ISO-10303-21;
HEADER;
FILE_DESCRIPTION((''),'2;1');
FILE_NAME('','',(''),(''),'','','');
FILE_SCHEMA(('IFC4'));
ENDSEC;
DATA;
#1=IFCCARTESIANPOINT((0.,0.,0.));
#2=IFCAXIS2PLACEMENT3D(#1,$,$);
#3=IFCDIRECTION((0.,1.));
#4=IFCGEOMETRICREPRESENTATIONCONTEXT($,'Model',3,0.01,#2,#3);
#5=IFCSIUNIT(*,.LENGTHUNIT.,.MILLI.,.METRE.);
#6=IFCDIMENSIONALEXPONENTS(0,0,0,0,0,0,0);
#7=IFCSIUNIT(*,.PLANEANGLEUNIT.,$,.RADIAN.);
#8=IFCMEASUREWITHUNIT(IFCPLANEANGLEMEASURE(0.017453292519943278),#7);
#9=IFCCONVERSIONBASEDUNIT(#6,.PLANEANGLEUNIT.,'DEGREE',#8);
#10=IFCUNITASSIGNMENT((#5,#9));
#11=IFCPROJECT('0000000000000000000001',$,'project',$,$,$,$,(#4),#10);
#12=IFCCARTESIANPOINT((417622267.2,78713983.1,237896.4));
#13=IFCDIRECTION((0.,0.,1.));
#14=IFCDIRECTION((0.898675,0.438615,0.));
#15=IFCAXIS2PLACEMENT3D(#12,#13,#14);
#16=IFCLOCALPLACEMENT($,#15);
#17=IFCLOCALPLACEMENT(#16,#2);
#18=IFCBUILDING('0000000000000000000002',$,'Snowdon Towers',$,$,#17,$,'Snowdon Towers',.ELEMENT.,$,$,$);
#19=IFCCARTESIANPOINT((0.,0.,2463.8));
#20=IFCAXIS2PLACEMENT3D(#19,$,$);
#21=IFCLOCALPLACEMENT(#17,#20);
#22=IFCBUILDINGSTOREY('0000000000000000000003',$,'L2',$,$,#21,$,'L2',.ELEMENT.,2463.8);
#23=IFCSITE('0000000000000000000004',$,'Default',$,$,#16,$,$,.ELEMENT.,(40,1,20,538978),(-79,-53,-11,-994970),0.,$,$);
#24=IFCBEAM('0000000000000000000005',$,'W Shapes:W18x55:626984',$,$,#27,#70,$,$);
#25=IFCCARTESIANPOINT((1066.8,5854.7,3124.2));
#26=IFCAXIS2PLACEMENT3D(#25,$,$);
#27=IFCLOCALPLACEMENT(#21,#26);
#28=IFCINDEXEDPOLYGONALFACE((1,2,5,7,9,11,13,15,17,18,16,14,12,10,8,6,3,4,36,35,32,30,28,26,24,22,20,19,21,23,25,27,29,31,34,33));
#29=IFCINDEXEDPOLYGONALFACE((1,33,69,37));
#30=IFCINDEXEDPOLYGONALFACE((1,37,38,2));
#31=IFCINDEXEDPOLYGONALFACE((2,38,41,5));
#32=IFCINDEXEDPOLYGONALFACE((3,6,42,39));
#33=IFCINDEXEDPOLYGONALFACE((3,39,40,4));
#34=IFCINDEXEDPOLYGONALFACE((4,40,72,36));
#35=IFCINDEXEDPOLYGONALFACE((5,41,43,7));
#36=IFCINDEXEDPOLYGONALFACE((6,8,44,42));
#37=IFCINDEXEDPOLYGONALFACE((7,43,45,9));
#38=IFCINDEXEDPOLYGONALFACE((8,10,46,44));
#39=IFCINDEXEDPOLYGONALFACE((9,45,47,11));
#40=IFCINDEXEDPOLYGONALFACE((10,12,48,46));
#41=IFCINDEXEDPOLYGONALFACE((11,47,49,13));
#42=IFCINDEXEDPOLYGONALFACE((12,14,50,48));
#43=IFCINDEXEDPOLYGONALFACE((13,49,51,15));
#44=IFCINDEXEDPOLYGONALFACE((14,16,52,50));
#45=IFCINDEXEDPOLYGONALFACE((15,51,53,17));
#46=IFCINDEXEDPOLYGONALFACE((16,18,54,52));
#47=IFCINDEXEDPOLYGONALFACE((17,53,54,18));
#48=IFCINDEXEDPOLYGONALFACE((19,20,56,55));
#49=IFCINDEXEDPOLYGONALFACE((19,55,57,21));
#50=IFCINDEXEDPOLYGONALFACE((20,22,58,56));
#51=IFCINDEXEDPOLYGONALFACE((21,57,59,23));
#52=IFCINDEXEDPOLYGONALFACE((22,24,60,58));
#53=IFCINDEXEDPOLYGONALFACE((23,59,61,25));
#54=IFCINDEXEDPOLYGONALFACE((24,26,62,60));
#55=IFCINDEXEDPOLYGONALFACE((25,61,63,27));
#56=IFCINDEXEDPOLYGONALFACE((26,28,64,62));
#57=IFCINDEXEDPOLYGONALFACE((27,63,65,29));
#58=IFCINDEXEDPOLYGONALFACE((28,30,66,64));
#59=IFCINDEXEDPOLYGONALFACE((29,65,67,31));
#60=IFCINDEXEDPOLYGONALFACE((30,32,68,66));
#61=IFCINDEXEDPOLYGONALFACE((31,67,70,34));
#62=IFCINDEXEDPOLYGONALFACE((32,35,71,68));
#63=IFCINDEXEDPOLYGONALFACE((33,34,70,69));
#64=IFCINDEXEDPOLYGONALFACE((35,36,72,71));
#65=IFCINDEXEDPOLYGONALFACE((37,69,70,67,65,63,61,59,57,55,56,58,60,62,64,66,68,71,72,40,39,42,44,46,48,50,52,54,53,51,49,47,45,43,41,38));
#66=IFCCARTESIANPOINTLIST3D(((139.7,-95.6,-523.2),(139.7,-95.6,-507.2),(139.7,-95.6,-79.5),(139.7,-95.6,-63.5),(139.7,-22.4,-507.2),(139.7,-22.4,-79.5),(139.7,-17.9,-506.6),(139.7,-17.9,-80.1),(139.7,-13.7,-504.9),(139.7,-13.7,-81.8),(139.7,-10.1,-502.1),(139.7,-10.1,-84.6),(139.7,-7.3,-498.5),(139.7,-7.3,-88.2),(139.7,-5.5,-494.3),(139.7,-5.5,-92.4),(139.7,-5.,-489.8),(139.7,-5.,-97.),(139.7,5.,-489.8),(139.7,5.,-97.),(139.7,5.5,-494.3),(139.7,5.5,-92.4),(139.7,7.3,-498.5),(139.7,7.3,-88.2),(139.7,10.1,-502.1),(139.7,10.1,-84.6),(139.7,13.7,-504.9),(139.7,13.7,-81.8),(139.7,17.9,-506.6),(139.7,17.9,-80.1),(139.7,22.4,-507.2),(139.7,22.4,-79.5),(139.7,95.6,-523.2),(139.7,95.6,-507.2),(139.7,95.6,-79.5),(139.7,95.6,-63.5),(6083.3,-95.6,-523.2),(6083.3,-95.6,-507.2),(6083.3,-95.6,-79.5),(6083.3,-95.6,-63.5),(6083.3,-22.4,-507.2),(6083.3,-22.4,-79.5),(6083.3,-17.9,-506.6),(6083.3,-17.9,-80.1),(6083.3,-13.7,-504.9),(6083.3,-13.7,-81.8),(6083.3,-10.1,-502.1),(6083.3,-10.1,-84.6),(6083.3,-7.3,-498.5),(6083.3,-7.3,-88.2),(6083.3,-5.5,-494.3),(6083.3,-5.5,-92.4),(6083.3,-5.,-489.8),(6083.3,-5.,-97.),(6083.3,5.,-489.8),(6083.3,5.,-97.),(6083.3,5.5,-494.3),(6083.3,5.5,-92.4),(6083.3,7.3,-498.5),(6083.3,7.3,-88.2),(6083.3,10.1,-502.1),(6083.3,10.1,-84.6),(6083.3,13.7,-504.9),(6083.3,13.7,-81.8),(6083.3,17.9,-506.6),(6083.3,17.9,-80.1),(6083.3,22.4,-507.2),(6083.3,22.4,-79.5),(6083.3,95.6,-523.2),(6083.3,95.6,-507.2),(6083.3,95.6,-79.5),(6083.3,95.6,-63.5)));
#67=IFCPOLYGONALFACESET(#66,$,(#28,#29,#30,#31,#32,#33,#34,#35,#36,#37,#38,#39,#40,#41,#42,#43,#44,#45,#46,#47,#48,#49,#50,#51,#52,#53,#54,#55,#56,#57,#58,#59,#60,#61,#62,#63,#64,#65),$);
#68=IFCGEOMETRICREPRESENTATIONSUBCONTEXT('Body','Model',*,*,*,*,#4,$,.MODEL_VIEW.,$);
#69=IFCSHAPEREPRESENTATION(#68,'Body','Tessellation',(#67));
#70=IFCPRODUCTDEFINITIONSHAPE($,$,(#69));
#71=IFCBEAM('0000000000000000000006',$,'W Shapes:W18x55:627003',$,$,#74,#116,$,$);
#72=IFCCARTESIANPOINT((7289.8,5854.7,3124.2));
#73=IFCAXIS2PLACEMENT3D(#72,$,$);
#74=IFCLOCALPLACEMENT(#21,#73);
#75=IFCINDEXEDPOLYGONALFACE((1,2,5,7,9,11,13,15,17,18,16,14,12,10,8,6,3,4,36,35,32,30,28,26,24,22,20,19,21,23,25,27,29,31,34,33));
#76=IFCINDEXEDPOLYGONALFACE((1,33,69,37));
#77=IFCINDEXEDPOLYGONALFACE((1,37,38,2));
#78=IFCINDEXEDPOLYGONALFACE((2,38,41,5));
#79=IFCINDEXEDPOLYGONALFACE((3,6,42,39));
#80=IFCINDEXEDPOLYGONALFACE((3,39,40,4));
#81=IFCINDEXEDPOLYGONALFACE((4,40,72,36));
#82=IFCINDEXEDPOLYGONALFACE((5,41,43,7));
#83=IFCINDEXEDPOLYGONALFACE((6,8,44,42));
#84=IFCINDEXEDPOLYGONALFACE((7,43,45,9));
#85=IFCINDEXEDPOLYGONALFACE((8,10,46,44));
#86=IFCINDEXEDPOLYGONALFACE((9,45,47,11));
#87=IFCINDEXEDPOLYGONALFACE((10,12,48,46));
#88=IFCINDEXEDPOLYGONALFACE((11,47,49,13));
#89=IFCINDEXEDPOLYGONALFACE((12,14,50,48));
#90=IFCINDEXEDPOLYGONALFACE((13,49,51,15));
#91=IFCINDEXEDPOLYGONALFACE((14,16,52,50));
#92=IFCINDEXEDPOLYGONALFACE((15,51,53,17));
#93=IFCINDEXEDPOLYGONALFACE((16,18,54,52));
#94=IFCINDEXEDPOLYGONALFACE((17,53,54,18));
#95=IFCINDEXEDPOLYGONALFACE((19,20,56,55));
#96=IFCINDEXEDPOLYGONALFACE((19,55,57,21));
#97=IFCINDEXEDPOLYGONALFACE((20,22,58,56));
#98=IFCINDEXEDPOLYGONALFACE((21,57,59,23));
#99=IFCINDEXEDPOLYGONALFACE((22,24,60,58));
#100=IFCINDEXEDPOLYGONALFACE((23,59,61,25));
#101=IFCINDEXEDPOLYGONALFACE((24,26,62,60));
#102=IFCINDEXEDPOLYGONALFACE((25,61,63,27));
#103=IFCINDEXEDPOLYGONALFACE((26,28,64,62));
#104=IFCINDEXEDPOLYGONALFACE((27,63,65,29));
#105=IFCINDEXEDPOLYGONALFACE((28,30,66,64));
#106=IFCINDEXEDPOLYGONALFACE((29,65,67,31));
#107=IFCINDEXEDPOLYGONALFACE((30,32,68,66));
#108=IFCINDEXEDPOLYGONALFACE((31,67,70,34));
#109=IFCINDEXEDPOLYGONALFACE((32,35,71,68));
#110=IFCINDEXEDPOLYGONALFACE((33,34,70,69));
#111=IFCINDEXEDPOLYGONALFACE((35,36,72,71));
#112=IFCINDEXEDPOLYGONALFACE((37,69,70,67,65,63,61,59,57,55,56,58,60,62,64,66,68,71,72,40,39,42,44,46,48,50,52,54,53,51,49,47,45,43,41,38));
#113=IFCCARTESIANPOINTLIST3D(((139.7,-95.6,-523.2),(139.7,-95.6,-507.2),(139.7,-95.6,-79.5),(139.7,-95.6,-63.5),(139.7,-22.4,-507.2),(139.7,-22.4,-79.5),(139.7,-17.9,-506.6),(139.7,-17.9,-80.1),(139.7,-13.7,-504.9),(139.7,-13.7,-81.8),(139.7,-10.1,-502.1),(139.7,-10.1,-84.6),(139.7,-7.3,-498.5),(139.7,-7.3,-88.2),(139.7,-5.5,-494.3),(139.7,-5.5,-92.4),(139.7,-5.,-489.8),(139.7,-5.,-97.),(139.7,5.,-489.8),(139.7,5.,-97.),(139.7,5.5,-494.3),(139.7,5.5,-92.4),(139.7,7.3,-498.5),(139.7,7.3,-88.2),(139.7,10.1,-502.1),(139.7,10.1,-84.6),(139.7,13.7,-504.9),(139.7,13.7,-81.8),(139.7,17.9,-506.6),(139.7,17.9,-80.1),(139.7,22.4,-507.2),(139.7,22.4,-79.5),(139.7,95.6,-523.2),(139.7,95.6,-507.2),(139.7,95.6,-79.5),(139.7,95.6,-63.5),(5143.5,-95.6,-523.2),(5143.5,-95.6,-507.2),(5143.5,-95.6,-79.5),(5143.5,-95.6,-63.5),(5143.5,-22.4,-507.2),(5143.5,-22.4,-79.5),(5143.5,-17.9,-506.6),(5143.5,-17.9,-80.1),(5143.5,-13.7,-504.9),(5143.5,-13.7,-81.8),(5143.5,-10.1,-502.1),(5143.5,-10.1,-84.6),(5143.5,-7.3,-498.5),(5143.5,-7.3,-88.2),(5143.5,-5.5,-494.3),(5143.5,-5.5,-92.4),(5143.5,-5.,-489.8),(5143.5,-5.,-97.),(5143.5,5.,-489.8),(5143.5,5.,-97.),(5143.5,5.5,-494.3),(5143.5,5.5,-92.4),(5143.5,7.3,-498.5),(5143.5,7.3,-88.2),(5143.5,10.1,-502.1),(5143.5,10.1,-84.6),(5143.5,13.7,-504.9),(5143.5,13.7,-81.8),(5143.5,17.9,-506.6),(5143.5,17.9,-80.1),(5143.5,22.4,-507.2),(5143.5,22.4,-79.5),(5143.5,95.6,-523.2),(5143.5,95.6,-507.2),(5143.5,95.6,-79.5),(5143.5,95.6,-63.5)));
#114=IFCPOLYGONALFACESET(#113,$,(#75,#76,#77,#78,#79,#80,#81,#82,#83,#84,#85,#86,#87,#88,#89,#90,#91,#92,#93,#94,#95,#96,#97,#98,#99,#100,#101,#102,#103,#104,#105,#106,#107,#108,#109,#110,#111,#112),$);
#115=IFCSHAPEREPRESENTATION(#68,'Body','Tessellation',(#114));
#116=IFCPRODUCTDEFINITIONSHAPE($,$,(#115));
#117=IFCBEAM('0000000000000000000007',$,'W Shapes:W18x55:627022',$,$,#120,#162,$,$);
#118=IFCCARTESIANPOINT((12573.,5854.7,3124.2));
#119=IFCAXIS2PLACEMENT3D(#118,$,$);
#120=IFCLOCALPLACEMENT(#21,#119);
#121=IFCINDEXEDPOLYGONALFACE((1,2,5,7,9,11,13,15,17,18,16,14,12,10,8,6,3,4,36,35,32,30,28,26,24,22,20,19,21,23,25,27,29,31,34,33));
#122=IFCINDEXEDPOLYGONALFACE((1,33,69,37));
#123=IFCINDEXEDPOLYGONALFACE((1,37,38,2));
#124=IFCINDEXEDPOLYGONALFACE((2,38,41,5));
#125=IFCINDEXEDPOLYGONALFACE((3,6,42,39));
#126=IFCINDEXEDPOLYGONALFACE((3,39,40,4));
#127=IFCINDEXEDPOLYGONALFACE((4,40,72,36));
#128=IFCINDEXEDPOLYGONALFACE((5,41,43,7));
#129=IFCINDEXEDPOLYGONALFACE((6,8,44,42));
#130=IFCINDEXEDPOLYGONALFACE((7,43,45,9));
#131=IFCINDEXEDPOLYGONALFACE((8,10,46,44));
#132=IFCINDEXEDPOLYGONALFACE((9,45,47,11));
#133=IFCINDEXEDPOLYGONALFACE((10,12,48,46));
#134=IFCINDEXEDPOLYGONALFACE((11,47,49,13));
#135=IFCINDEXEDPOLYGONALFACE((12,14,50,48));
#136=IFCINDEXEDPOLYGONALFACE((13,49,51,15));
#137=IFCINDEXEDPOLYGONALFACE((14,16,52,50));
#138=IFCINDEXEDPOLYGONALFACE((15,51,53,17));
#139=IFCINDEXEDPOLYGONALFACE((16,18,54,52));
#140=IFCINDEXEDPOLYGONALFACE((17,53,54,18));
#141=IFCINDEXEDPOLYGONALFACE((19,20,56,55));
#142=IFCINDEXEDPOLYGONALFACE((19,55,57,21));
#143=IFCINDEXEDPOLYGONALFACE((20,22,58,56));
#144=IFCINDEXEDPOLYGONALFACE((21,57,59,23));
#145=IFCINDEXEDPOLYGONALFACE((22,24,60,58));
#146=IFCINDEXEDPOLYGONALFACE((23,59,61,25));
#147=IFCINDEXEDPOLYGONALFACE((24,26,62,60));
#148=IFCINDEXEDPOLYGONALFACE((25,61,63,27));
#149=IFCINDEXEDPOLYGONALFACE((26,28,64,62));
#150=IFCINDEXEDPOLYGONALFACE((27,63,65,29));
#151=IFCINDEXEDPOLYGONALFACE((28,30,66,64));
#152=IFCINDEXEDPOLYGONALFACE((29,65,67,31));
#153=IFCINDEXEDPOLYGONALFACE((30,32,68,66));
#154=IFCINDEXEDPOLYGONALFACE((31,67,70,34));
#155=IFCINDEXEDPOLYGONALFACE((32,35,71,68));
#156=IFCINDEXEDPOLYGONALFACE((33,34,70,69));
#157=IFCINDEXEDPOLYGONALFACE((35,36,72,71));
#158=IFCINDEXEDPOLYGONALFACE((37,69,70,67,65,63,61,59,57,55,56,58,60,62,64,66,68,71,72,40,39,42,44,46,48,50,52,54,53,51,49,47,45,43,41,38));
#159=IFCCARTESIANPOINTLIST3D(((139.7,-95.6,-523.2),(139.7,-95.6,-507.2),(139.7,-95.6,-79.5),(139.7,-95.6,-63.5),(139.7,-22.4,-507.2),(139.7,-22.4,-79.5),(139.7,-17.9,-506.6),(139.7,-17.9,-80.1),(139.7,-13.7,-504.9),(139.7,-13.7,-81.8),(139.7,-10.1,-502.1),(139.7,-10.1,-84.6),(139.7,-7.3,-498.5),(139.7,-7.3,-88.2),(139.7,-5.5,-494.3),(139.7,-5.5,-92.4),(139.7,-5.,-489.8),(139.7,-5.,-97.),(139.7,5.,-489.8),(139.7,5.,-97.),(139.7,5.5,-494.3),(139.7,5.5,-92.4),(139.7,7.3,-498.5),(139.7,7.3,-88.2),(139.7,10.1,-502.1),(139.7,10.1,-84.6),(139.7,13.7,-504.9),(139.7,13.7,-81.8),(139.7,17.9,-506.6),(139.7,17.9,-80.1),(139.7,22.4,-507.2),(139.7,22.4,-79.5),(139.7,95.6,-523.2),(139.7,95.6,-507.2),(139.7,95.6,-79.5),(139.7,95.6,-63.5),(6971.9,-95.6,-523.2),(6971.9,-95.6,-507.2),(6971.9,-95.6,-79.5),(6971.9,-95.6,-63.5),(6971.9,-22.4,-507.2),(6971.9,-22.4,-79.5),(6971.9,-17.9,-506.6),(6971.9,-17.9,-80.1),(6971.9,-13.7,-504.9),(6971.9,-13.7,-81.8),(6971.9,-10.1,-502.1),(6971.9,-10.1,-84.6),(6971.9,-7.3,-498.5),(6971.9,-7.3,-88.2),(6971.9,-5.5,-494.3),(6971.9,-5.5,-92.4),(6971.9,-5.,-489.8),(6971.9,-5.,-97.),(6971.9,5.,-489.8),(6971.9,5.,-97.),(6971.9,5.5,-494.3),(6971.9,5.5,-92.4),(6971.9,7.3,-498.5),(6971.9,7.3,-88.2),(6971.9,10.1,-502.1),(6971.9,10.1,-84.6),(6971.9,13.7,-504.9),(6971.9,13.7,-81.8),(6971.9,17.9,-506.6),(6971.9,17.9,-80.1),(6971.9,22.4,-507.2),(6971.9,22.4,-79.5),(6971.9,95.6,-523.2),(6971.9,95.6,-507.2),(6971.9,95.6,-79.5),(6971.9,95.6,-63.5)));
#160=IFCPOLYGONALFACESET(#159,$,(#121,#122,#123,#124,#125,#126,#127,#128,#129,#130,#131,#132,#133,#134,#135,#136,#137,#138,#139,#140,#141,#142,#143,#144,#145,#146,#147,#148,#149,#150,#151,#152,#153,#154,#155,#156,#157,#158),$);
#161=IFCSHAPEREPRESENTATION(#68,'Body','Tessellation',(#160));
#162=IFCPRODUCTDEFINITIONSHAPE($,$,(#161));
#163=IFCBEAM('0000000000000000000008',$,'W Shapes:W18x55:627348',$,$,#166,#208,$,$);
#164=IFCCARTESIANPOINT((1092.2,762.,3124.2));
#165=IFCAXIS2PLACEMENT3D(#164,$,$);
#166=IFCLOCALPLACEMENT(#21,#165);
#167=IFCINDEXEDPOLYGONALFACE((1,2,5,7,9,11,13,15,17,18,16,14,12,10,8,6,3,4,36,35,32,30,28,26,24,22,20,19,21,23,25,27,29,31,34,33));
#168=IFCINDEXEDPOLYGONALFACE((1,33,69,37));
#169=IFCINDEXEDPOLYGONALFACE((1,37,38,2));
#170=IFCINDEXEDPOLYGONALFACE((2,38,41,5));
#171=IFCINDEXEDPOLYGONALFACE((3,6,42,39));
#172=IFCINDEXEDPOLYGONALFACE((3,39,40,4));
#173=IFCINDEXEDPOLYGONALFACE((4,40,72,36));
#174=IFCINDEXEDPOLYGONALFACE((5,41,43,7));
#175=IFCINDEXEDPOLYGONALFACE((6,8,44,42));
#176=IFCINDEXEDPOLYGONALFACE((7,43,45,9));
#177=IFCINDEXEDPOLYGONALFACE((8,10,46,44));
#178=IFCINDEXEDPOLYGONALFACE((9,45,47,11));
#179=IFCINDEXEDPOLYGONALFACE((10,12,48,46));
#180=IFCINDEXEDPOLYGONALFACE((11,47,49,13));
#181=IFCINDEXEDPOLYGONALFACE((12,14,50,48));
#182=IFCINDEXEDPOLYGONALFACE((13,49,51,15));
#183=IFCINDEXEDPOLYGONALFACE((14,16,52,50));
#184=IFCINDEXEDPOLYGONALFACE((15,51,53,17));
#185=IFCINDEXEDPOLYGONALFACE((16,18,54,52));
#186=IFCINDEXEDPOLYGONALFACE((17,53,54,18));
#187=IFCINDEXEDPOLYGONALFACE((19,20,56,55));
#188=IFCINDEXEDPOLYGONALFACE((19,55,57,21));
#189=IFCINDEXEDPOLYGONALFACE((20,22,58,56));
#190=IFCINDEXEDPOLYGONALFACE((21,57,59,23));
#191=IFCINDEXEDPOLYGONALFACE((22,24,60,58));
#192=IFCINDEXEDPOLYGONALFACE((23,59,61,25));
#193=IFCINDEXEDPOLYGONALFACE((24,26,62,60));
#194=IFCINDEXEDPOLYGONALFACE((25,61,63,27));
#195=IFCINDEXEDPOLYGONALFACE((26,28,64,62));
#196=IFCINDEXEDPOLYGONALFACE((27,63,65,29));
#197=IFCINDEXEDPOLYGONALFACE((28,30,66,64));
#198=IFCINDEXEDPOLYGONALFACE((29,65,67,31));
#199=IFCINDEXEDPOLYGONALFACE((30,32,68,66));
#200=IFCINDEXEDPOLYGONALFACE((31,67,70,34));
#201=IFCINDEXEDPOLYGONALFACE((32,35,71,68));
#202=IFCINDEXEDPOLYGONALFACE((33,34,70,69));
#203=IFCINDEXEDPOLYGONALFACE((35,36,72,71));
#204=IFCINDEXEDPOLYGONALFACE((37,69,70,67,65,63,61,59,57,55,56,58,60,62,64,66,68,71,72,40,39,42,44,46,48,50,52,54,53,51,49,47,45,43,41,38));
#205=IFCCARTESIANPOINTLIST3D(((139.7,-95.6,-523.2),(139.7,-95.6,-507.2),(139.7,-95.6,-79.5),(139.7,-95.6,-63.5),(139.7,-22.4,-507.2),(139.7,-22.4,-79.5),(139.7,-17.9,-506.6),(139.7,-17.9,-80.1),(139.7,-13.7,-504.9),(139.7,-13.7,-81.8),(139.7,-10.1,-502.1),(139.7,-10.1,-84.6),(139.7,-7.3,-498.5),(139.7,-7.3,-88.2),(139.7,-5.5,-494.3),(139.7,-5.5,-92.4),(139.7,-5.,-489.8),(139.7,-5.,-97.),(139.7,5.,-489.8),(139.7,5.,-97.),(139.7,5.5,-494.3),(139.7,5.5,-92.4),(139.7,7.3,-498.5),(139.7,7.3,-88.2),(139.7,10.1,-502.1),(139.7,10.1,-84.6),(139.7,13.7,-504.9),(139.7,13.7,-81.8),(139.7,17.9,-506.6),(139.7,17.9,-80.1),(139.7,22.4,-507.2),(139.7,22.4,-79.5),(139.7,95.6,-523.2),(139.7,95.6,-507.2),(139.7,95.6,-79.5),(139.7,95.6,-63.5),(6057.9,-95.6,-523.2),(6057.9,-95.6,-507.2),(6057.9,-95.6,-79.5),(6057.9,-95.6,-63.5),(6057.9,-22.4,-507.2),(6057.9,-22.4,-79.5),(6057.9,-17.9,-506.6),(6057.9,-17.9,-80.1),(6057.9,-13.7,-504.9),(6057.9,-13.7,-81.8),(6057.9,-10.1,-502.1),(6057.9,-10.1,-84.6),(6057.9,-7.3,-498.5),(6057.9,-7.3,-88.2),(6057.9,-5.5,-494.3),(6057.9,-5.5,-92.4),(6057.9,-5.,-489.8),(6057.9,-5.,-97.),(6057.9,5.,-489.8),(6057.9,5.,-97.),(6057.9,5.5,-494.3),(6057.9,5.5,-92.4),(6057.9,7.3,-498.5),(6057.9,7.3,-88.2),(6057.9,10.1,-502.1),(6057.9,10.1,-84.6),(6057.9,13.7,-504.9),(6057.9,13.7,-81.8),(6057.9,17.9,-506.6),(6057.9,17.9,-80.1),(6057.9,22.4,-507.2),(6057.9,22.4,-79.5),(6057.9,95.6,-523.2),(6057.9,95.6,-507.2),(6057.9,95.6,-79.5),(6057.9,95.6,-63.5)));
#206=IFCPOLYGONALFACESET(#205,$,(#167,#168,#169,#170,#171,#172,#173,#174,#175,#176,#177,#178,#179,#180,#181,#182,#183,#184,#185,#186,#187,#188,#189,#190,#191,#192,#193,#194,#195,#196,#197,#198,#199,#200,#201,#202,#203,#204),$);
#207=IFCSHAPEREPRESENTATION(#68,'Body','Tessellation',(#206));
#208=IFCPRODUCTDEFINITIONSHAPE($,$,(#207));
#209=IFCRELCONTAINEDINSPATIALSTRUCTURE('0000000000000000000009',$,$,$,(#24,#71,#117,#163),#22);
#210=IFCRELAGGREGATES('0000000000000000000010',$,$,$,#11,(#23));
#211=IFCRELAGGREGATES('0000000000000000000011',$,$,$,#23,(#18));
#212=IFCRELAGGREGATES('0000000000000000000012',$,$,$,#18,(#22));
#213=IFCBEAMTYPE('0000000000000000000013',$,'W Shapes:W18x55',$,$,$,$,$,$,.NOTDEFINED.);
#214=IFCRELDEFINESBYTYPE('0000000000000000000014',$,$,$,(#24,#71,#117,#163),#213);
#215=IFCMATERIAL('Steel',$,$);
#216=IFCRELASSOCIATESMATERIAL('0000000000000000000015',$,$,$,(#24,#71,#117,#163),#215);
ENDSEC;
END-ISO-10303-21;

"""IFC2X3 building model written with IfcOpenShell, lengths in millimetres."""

from ifc_helpers import new_model, entity, si_unit, converted_unit, direction, frame, frame_2d, origin, place, context, subcontext, project, spatial, i_section, extrude, material, type_object, element, save


model = new_model("IFC2X3")

# Units and contexts
model_context = context("Model", 3, precision=0.01, world=origin(), true_north=direction((0.0, 1.0)))
body_context = subcontext(model_context, "Body", "Model", "MODEL_VIEW")
ifc_project = project(units=[si_unit("LENGTHUNIT", "METRE", prefix="MILLI"), converted_unit("PLANEANGLEUNIT", "DEGREE", entity("IfcPlaneAngleMeasure", 0.017453292519943278), si_unit("PLANEANGLEUNIT", "RADIAN"), dimensions=[0, 0, 0, 0, 0, 0, 0])], contexts=[model_context])

# Site, building, storey
site_placement = place(None, frame((417622267.2, 78713983.1, 237896.4), z_axis=(0.0, 0.0, 1.0), x_axis=(0.898675, 0.438615, 0.0)))
site = spatial("IfcSite", under=ifc_project, at=site_placement, Name="Default", CompositionType="ELEMENT", RefLatitude=(40, 1, 20, 538978), RefLongitude=(-79, -53, -11, -994970), RefElevation=0.0)
building_placement = place(site_placement, origin())
building = spatial("IfcBuilding", under=site, at=building_placement, Name="Snowdon Towers", LongName="Snowdon Towers", CompositionType="ELEMENT")
storey_placement = place(building_placement, frame((0.0, 0.0, 2463.8)))
storey = spatial("IfcBuildingStorey", under=building, at=storey_placement, Name="L2", LongName="L2", CompositionType="ELEMENT", Elevation=2463.8)

# Shared definitions
ifc_material_1 = material(Name="Steel")

# Beams
beam_type_1 = type_object("IfcBeamType", Name="W Shapes:W18x55", PredefinedType="NOTDEFINED")
beam_1_placement = place(storey_placement, frame((1066.8, 5854.7, 3124.2)))
element("IfcBeam", 1, at=beam_1_placement, inside=storey, type_object=beam_type_1, material=ifc_material_1, Name="W Shapes:W18x55:626984", context=body_context, shape_type="SweptSolid", body=[
    extrude(i_section(OverallWidth=191.3, OverallDepth=459.7, WebThickness=9.9, FlangeThickness=16.0, FilletRadius=17.5, at=frame_2d((0.0, 0.0), x_axis=(0.0, 1.0))), frame((139.7, 0.0, -293.4), z_axis=(1.0, 0.0, 0.0), x_axis=(0.0, 0.0, -1.0)), (0.0, 0.0, 1.0), 5943.6),
])
beam_2_placement = place(storey_placement, frame((7289.8, 5854.7, 3124.2)))
element("IfcBeam", 2, at=beam_2_placement, inside=storey, type_object=beam_type_1, material=ifc_material_1, Name="W Shapes:W18x55:627003", context=body_context, shape_type="SweptSolid", body=[
    extrude(i_section(OverallWidth=191.3, OverallDepth=459.7, WebThickness=9.9, FlangeThickness=16.0, FilletRadius=17.5, at=frame_2d((0.0, 0.0), x_axis=(0.0, 1.0))), frame((139.7, 0.0, -293.4), z_axis=(1.0, 0.0, 0.0), x_axis=(0.0, 0.0, -1.0)), (0.0, 0.0, 1.0), 5003.8),
])
beam_3_placement = place(storey_placement, frame((12573.0, 5854.7, 3124.2)))
element("IfcBeam", 3, at=beam_3_placement, inside=storey, type_object=beam_type_1, material=ifc_material_1, Name="W Shapes:W18x55:627022", context=body_context, shape_type="SweptSolid", body=[
    extrude(i_section(OverallWidth=191.3, OverallDepth=459.7, WebThickness=9.9, FlangeThickness=16.0, FilletRadius=17.5, at=frame_2d((0.0, 0.0), x_axis=(0.0, 1.0))), frame((139.7, 0.0, -293.4), z_axis=(1.0, 0.0, 0.0), x_axis=(0.0, 0.0, -1.0)), (0.0, 0.0, 1.0), 6832.2),
])
beam_4_placement = place(storey_placement, frame((1092.2, 762.0, 3124.2)))
element("IfcBeam", 4, at=beam_4_placement, inside=storey, type_object=beam_type_1, material=ifc_material_1, Name="W Shapes:W18x55:627348", context=body_context, shape_type="SweptSolid", body=[
    extrude(i_section(OverallWidth=191.3, OverallDepth=459.7, WebThickness=9.9, FlangeThickness=16.0, FilletRadius=17.5, at=frame_2d((0.0, 0.0), x_axis=(0.0, 1.0))), frame((139.7, 0.0, -293.4), z_axis=(1.0, 0.0, 0.0), x_axis=(0.0, 0.0, -1.0)), (0.0, 0.0, 1.0), 5918.2),
])

save(model, "model.ifc")
